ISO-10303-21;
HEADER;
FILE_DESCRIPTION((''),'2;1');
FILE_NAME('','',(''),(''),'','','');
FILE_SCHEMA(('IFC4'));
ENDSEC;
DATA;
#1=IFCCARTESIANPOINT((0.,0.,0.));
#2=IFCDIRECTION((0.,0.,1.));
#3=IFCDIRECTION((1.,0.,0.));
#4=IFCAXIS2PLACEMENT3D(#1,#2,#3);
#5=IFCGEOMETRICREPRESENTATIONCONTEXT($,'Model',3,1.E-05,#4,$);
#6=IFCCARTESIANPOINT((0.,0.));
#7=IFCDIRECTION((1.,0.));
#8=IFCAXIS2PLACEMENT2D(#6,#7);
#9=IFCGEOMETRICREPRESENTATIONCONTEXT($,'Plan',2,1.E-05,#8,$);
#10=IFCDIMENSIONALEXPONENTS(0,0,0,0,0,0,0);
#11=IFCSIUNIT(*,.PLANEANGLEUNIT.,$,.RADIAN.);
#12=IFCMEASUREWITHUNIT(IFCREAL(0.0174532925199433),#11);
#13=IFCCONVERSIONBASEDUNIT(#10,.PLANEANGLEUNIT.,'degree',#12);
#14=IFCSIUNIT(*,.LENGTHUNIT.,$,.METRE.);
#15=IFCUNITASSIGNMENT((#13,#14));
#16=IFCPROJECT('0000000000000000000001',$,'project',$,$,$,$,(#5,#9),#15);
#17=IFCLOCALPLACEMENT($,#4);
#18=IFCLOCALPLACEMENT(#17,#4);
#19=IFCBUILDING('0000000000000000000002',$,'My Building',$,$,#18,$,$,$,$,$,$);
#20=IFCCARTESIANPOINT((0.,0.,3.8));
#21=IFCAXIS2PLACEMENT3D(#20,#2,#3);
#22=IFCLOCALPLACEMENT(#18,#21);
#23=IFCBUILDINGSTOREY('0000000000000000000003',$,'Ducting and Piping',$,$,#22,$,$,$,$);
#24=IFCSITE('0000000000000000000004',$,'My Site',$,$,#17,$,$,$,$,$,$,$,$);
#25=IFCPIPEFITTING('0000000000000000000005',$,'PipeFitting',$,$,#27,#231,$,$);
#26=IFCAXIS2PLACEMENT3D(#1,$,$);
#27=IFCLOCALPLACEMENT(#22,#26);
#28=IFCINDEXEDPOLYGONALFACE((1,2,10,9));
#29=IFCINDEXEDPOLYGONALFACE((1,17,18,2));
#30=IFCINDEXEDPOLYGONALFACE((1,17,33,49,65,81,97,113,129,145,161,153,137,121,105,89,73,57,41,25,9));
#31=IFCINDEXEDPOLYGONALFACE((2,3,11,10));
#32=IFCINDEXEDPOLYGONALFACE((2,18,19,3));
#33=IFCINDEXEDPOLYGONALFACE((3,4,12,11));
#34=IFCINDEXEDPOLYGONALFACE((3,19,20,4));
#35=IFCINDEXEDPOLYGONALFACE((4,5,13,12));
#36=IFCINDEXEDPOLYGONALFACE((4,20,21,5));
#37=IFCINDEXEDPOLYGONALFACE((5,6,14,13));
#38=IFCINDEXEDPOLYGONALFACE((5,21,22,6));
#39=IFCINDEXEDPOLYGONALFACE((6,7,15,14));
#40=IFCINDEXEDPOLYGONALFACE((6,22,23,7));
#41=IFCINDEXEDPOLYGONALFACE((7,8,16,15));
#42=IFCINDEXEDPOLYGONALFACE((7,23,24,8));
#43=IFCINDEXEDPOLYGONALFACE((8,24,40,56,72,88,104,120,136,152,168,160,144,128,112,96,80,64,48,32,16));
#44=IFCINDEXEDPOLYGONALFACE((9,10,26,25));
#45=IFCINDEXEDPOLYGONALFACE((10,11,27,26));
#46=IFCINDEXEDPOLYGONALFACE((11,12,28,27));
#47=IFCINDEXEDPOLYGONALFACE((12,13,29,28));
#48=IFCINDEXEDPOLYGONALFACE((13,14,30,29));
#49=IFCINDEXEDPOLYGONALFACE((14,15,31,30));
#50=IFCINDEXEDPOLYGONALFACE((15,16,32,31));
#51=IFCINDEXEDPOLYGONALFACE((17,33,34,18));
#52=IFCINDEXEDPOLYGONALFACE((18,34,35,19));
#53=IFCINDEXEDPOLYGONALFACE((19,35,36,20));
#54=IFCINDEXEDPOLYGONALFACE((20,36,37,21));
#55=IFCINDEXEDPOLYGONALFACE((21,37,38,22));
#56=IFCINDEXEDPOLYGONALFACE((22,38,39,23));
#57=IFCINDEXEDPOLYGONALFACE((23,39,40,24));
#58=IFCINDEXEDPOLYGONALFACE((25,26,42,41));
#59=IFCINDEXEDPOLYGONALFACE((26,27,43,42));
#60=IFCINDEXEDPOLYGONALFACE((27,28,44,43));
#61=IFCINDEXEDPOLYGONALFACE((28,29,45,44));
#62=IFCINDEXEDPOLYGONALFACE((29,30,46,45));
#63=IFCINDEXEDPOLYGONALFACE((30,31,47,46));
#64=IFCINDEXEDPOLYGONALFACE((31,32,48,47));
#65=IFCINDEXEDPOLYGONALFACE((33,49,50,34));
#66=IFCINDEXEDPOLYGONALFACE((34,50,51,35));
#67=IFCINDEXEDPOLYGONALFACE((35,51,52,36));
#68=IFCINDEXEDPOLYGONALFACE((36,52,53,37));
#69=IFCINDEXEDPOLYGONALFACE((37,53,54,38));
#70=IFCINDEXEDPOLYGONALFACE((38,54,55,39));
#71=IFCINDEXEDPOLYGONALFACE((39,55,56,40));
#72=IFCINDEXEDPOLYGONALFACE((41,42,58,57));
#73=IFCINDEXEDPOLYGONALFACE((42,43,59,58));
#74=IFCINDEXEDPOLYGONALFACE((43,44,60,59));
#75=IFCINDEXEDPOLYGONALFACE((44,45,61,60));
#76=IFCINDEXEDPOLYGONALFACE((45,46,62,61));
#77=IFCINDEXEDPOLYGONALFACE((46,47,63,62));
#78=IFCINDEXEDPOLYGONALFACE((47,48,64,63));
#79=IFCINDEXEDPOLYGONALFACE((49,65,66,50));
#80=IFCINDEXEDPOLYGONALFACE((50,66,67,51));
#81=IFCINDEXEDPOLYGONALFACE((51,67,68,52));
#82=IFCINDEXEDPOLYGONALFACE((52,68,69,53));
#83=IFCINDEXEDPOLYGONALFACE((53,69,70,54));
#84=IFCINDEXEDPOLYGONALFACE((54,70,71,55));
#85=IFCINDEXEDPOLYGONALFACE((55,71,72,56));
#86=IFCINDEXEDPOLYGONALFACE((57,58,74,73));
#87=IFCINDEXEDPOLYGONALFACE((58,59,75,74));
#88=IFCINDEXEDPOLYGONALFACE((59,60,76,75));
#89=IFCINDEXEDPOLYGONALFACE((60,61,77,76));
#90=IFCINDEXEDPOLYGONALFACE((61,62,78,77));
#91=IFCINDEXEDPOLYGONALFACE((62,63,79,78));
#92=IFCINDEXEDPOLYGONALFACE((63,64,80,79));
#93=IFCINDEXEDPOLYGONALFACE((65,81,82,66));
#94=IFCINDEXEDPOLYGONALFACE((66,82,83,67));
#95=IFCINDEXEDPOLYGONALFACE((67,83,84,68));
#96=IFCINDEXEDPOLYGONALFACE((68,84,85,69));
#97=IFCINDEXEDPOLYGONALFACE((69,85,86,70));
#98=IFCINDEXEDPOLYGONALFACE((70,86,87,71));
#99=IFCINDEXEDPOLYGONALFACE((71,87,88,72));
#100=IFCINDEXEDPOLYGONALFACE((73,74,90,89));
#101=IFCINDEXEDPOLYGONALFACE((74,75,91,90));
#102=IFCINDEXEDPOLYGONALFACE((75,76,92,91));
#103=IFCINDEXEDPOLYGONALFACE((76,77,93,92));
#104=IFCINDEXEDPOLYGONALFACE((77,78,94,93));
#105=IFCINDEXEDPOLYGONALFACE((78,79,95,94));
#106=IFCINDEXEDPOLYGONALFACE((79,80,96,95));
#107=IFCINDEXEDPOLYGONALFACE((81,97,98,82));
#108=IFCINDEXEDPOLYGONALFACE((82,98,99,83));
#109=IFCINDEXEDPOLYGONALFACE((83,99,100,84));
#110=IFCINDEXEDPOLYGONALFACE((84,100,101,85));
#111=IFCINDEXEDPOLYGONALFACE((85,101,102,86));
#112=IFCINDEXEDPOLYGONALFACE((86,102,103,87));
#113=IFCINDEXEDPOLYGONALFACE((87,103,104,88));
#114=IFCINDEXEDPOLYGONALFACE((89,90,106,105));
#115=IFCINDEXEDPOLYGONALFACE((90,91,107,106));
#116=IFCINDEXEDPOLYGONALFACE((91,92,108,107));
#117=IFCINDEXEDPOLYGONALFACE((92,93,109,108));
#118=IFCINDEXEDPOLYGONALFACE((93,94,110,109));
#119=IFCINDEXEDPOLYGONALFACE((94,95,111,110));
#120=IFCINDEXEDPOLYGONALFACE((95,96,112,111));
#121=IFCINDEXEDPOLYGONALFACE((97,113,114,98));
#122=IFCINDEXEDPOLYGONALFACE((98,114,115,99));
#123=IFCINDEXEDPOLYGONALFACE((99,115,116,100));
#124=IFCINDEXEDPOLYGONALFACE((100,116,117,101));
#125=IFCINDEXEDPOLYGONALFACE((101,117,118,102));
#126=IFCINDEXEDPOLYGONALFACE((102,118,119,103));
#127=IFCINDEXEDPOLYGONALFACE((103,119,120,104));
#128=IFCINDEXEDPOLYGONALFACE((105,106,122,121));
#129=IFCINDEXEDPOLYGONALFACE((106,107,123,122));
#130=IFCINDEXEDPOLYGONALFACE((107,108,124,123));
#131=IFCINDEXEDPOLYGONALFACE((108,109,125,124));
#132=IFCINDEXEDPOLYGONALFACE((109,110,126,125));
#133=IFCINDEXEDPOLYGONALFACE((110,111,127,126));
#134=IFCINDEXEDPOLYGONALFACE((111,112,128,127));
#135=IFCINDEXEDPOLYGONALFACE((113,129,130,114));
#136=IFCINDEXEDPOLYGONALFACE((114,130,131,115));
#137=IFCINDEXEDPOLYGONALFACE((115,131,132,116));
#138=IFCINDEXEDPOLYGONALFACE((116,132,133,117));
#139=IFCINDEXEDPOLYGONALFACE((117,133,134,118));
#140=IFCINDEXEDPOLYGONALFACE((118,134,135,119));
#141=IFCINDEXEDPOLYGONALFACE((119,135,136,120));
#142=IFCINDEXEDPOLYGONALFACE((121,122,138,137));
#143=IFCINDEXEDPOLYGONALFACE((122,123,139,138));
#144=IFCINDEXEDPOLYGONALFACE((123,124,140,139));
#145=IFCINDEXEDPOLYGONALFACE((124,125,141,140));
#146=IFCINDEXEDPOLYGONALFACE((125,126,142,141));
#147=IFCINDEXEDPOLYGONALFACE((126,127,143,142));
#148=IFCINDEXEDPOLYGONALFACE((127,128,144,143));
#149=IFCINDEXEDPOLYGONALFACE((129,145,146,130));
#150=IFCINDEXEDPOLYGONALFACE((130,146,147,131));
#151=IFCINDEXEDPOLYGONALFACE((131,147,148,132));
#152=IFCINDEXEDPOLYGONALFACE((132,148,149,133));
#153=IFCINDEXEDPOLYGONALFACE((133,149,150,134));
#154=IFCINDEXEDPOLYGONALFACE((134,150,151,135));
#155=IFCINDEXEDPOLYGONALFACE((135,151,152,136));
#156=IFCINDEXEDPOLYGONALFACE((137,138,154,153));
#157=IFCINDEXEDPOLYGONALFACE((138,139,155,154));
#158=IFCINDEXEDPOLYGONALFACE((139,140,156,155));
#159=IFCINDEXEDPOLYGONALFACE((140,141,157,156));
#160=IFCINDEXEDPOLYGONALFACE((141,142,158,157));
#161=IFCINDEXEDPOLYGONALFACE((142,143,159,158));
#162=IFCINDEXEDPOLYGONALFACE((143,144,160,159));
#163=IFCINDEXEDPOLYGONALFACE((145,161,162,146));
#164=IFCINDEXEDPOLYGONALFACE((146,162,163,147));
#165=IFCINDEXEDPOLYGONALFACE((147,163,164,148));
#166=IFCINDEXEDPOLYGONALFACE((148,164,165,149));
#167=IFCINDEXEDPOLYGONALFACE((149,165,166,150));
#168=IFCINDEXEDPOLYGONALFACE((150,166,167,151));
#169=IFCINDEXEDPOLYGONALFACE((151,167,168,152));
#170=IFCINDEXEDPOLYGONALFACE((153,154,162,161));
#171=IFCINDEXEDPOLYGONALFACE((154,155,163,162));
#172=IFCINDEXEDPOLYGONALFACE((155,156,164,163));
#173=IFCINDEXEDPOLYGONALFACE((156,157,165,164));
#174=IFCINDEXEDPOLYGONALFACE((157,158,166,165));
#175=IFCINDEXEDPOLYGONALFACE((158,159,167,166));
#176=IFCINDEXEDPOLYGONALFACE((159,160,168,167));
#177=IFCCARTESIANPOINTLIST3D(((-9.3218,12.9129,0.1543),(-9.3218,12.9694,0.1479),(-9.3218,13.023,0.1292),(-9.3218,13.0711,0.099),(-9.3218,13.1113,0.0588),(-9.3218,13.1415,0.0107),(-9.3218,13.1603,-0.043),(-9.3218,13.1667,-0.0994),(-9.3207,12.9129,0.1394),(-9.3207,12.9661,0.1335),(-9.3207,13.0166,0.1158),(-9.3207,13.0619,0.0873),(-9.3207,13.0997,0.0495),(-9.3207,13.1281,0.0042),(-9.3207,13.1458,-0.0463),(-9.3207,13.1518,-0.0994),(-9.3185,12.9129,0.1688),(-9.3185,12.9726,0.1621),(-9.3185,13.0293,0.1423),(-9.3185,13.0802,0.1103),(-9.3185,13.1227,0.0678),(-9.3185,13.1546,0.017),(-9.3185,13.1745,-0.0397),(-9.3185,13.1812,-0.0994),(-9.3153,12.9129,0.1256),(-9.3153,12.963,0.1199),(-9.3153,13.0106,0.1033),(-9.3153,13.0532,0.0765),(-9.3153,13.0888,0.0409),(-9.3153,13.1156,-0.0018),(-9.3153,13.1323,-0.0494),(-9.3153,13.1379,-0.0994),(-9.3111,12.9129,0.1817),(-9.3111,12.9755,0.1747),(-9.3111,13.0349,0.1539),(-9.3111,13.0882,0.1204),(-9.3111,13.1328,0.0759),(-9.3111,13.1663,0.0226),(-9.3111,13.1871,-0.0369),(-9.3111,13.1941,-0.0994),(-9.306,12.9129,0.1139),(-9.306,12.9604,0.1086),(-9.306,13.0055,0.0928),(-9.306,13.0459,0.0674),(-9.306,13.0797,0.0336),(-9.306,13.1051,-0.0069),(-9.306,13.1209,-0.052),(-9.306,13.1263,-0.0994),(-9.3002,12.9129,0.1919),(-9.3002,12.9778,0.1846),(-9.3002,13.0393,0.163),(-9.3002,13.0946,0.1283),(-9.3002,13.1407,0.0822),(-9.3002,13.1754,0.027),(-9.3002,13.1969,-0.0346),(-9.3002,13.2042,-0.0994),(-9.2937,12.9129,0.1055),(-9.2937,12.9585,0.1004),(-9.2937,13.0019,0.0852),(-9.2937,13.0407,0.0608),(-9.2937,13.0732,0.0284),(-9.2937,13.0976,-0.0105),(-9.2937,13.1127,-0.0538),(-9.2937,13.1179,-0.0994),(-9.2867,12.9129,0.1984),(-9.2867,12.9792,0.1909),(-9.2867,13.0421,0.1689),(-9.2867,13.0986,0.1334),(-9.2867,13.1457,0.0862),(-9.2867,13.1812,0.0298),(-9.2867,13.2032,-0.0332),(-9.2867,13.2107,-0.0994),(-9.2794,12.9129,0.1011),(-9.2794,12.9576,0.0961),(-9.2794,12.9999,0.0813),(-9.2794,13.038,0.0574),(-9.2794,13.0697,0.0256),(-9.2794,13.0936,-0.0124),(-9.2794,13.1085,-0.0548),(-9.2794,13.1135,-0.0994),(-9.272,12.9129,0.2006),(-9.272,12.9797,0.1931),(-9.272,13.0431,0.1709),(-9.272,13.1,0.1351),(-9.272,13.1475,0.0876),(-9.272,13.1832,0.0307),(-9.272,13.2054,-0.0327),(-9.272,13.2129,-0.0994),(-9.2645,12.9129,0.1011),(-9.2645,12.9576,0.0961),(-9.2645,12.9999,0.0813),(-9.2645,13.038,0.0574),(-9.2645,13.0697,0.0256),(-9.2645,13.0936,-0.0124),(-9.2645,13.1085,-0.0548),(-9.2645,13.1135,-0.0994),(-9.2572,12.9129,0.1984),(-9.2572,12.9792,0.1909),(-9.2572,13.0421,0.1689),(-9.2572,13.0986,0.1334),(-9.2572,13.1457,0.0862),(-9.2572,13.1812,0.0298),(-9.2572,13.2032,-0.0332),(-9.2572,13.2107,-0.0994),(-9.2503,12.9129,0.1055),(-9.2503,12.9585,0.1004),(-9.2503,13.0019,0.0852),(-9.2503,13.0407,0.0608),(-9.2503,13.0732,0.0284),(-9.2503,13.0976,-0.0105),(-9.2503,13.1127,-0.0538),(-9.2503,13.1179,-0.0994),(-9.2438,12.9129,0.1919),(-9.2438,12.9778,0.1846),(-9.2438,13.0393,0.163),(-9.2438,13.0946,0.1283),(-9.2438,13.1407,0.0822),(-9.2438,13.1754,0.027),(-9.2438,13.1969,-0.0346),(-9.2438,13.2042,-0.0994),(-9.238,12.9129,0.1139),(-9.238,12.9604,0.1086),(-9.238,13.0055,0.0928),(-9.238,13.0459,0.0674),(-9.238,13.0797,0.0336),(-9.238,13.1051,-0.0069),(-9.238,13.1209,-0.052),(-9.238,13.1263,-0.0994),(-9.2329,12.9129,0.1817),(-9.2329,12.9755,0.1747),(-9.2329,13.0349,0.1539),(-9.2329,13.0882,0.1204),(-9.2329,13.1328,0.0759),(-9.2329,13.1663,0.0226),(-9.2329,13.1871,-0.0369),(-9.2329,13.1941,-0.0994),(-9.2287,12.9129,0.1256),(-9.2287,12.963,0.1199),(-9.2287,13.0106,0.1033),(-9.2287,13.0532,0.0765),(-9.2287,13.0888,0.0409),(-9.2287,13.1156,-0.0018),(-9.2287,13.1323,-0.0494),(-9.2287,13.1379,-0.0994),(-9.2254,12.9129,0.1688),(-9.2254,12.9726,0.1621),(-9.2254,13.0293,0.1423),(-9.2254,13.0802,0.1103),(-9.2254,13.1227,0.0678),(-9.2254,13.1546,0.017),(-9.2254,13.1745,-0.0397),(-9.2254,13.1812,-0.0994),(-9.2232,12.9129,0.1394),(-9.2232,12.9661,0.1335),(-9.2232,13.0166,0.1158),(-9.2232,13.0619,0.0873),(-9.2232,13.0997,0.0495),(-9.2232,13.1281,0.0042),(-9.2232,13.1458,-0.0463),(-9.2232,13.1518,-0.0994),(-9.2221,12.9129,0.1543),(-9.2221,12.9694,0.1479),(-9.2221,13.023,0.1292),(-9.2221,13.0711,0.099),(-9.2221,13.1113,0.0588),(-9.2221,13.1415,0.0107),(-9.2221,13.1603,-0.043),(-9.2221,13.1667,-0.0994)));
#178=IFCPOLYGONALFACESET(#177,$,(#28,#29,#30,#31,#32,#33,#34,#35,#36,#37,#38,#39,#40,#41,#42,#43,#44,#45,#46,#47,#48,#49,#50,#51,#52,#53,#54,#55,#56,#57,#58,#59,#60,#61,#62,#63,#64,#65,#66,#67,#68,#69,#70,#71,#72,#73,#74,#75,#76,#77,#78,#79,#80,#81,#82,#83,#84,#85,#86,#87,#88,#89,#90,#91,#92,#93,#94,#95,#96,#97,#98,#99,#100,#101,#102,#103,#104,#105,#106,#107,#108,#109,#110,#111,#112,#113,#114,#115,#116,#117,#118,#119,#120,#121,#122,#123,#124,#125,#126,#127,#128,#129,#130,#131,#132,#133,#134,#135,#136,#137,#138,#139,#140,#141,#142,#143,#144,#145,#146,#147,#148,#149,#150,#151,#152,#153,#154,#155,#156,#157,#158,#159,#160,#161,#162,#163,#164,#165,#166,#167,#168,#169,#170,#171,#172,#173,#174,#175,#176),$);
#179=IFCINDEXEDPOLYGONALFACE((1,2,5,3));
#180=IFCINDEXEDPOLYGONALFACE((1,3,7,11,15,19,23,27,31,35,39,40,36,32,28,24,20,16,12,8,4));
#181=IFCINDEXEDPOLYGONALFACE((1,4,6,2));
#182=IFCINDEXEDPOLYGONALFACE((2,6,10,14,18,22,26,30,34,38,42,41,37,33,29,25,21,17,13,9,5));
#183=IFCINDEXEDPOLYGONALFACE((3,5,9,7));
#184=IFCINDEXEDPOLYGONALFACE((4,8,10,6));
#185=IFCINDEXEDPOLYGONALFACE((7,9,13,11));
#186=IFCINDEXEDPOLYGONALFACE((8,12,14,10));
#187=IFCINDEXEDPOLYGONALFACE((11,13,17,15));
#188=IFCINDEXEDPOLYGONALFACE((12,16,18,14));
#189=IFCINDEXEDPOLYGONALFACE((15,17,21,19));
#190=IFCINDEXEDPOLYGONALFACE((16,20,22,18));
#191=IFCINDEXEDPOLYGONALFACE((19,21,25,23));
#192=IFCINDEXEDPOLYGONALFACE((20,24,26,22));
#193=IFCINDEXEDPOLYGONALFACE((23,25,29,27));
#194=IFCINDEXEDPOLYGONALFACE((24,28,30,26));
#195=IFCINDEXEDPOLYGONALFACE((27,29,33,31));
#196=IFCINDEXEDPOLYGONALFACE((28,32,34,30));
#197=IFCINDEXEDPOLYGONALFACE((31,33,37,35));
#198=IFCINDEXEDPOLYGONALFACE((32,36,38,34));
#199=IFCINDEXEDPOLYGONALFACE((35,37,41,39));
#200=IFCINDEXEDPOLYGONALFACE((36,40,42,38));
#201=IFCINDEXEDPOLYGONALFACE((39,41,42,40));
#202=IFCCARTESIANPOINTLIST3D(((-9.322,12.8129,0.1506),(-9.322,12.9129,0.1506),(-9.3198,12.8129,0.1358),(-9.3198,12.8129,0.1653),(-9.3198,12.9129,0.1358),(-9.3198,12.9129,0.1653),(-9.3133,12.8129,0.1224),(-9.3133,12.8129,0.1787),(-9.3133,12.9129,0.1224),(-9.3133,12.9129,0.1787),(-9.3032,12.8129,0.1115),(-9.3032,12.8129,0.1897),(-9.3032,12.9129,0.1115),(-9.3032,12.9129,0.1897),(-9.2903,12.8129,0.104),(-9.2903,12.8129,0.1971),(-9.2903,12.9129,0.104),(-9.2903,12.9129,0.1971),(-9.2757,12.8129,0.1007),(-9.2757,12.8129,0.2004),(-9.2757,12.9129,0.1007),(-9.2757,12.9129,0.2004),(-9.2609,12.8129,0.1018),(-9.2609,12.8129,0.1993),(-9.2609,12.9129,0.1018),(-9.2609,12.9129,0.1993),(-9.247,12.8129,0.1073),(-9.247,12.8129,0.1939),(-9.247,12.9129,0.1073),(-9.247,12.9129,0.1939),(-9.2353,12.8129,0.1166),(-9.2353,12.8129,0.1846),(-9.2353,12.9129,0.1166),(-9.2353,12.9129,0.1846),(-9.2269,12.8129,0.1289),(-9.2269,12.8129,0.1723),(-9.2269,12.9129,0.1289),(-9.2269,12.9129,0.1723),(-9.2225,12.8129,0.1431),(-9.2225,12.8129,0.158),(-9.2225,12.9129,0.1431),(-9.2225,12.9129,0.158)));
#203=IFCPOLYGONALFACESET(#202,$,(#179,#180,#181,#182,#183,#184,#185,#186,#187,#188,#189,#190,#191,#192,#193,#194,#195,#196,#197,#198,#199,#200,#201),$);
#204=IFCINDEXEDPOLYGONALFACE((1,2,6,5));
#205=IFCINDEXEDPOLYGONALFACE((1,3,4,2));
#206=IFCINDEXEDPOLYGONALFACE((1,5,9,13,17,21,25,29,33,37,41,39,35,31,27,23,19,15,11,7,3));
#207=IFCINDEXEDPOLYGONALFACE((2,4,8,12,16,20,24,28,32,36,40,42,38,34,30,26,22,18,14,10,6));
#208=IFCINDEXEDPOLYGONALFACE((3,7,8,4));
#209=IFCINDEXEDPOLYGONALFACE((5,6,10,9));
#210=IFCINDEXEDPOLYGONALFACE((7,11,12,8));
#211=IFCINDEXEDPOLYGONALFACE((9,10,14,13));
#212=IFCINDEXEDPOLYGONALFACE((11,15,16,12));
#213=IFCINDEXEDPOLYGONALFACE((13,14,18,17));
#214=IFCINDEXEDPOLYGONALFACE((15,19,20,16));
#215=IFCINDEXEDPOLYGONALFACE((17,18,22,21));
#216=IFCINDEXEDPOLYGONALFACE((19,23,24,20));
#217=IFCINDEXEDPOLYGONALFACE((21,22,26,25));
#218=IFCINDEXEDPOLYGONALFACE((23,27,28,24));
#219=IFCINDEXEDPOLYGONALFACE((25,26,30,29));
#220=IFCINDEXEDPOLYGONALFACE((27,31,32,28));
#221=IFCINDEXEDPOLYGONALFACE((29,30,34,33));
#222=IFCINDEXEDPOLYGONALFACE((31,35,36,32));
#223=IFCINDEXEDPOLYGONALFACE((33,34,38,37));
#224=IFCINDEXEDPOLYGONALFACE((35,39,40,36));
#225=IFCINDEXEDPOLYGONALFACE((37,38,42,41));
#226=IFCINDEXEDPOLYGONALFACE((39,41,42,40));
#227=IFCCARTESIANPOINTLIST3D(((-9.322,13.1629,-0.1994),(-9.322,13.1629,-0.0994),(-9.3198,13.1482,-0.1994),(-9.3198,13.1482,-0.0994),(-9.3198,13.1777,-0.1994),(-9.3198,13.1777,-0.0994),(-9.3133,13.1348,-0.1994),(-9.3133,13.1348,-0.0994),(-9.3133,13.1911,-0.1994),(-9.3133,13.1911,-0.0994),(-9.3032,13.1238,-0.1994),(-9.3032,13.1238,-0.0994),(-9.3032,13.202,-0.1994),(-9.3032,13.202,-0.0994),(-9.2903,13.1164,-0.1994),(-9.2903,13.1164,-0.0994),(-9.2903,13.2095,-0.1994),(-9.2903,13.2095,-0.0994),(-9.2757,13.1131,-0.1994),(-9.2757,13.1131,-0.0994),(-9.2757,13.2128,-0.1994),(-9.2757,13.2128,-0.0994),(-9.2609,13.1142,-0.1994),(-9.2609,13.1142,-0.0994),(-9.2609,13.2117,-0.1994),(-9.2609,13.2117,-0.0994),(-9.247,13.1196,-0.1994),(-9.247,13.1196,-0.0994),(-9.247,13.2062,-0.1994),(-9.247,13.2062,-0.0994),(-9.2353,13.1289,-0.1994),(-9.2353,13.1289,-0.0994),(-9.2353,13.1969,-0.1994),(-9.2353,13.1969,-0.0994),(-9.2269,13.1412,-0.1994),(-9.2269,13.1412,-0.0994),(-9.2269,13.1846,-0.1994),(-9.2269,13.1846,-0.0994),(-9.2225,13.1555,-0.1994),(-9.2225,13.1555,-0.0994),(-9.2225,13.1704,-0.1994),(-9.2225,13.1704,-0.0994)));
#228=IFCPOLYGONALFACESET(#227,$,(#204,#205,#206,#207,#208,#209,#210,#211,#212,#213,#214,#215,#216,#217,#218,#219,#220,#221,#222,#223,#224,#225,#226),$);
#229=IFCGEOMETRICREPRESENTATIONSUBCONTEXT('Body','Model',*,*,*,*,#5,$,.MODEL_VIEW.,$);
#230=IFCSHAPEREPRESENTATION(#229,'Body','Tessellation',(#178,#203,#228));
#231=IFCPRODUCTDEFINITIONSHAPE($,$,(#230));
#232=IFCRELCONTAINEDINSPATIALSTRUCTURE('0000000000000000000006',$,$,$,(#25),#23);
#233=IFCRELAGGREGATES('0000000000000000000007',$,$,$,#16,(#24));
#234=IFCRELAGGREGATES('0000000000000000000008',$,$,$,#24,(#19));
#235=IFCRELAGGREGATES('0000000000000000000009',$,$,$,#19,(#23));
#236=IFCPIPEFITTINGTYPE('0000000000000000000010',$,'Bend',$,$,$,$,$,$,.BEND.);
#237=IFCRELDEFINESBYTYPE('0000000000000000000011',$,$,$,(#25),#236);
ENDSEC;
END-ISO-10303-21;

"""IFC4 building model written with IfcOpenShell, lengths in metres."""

from ifc_helpers import new_model, entity, si_unit, converted_unit, frame, origin_with_axes, origin_2d_with_axis, place, context, subcontext, project, spatial, circle, extrude, source, transform, mapped, type_object, type_shapes, element, save


model = new_model("IFC4")

# Units and contexts
model_context = context("Model", 3, precision=1e-05, world=origin_with_axes())
plan_context = context("Plan", 2, precision=1e-05, world=origin_2d_with_axis())
body_context = subcontext(model_context, "Body", "Model", "MODEL_VIEW")
ifc_project = project(units=[converted_unit("PLANEANGLEUNIT", "degree", entity("IfcReal", 0.0174532925199433), si_unit("PLANEANGLEUNIT", "RADIAN"), dimensions=[0, 0, 0, 0, 0, 0, 0]), si_unit("LENGTHUNIT", "METRE")], contexts=[model_context, plan_context])

# Site, building, storey
site_placement = place(None, origin_with_axes())
site = spatial("IfcSite", under=ifc_project, at=site_placement, Name="My Site")
building_placement = place(site_placement, origin_with_axes())
building = spatial("IfcBuilding", under=site, at=building_placement, Name="My Building")
storey_placement = place(building_placement, frame((0.0, 0.0, 3.8), z_axis=(0.0, 0.0, 1.0), x_axis=(1.0, 0.0, 0.0)))
storey = spatial("IfcBuildingStorey", under=building, at=storey_placement, Name="Ducting and Piping")

# Pipe fitting
pipe_fitting_type = type_object("IfcPipeFittingType", Name="Bend", PredefinedType="BEND")
shared_shape = source(origin_with_axes(), body_context, "Body", "SolidModel", [
    entity("IfcSweptDiskSolid", entity("IfcIndexedPolyCurve", entity("IfcCartesianPointList3D", [[0.0, 0.0, 0.1], [0.0, -0.0732, 0.2768], [0.0, -0.25, 0.35]]), [entity("IfcArcIndex", [1, 2, 3])]), 0.05),
    extrude(circle(Radius=0.05), origin_with_axes(), (0.0, 0.0, 1.0), 0.1),
    extrude(circle(Radius=0.05), frame((0.0, -0.25, 0.35), z_axis=(0.0, -1.0, 0.0), x_axis=(1.0, 0.0, 0.0)), (0.0, 0.0, 1.0), 0.1),
])
type_shapes(pipe_fitting_type, [shared_shape])
for number, where, z_axis, x_axis, name in (
    (1, (-9.272, 12.8129, 0.1506), (0.0, 1.0, 0.0), (-1.0, 0.0, 0.0), "PipeFitting"),
):
    element("IfcPipeFitting", number, at=place(storey_placement, frame(where, z_axis=z_axis, x_axis=x_axis)), inside=storey, type_object=pipe_fitting_type, Name=name, context=body_context, shape_type="MappedRepresentation", body=[
        mapped(shared_shape, transform((0.0, 0.0, 0.0), x_axis=(1.0, 0.0, 0.0), y_axis=(0.0, 1.0, 0.0), z_axis=(0.0, 0.0, 1.0), scale=1.0)),
    ])

save(model, "model.ifc")
